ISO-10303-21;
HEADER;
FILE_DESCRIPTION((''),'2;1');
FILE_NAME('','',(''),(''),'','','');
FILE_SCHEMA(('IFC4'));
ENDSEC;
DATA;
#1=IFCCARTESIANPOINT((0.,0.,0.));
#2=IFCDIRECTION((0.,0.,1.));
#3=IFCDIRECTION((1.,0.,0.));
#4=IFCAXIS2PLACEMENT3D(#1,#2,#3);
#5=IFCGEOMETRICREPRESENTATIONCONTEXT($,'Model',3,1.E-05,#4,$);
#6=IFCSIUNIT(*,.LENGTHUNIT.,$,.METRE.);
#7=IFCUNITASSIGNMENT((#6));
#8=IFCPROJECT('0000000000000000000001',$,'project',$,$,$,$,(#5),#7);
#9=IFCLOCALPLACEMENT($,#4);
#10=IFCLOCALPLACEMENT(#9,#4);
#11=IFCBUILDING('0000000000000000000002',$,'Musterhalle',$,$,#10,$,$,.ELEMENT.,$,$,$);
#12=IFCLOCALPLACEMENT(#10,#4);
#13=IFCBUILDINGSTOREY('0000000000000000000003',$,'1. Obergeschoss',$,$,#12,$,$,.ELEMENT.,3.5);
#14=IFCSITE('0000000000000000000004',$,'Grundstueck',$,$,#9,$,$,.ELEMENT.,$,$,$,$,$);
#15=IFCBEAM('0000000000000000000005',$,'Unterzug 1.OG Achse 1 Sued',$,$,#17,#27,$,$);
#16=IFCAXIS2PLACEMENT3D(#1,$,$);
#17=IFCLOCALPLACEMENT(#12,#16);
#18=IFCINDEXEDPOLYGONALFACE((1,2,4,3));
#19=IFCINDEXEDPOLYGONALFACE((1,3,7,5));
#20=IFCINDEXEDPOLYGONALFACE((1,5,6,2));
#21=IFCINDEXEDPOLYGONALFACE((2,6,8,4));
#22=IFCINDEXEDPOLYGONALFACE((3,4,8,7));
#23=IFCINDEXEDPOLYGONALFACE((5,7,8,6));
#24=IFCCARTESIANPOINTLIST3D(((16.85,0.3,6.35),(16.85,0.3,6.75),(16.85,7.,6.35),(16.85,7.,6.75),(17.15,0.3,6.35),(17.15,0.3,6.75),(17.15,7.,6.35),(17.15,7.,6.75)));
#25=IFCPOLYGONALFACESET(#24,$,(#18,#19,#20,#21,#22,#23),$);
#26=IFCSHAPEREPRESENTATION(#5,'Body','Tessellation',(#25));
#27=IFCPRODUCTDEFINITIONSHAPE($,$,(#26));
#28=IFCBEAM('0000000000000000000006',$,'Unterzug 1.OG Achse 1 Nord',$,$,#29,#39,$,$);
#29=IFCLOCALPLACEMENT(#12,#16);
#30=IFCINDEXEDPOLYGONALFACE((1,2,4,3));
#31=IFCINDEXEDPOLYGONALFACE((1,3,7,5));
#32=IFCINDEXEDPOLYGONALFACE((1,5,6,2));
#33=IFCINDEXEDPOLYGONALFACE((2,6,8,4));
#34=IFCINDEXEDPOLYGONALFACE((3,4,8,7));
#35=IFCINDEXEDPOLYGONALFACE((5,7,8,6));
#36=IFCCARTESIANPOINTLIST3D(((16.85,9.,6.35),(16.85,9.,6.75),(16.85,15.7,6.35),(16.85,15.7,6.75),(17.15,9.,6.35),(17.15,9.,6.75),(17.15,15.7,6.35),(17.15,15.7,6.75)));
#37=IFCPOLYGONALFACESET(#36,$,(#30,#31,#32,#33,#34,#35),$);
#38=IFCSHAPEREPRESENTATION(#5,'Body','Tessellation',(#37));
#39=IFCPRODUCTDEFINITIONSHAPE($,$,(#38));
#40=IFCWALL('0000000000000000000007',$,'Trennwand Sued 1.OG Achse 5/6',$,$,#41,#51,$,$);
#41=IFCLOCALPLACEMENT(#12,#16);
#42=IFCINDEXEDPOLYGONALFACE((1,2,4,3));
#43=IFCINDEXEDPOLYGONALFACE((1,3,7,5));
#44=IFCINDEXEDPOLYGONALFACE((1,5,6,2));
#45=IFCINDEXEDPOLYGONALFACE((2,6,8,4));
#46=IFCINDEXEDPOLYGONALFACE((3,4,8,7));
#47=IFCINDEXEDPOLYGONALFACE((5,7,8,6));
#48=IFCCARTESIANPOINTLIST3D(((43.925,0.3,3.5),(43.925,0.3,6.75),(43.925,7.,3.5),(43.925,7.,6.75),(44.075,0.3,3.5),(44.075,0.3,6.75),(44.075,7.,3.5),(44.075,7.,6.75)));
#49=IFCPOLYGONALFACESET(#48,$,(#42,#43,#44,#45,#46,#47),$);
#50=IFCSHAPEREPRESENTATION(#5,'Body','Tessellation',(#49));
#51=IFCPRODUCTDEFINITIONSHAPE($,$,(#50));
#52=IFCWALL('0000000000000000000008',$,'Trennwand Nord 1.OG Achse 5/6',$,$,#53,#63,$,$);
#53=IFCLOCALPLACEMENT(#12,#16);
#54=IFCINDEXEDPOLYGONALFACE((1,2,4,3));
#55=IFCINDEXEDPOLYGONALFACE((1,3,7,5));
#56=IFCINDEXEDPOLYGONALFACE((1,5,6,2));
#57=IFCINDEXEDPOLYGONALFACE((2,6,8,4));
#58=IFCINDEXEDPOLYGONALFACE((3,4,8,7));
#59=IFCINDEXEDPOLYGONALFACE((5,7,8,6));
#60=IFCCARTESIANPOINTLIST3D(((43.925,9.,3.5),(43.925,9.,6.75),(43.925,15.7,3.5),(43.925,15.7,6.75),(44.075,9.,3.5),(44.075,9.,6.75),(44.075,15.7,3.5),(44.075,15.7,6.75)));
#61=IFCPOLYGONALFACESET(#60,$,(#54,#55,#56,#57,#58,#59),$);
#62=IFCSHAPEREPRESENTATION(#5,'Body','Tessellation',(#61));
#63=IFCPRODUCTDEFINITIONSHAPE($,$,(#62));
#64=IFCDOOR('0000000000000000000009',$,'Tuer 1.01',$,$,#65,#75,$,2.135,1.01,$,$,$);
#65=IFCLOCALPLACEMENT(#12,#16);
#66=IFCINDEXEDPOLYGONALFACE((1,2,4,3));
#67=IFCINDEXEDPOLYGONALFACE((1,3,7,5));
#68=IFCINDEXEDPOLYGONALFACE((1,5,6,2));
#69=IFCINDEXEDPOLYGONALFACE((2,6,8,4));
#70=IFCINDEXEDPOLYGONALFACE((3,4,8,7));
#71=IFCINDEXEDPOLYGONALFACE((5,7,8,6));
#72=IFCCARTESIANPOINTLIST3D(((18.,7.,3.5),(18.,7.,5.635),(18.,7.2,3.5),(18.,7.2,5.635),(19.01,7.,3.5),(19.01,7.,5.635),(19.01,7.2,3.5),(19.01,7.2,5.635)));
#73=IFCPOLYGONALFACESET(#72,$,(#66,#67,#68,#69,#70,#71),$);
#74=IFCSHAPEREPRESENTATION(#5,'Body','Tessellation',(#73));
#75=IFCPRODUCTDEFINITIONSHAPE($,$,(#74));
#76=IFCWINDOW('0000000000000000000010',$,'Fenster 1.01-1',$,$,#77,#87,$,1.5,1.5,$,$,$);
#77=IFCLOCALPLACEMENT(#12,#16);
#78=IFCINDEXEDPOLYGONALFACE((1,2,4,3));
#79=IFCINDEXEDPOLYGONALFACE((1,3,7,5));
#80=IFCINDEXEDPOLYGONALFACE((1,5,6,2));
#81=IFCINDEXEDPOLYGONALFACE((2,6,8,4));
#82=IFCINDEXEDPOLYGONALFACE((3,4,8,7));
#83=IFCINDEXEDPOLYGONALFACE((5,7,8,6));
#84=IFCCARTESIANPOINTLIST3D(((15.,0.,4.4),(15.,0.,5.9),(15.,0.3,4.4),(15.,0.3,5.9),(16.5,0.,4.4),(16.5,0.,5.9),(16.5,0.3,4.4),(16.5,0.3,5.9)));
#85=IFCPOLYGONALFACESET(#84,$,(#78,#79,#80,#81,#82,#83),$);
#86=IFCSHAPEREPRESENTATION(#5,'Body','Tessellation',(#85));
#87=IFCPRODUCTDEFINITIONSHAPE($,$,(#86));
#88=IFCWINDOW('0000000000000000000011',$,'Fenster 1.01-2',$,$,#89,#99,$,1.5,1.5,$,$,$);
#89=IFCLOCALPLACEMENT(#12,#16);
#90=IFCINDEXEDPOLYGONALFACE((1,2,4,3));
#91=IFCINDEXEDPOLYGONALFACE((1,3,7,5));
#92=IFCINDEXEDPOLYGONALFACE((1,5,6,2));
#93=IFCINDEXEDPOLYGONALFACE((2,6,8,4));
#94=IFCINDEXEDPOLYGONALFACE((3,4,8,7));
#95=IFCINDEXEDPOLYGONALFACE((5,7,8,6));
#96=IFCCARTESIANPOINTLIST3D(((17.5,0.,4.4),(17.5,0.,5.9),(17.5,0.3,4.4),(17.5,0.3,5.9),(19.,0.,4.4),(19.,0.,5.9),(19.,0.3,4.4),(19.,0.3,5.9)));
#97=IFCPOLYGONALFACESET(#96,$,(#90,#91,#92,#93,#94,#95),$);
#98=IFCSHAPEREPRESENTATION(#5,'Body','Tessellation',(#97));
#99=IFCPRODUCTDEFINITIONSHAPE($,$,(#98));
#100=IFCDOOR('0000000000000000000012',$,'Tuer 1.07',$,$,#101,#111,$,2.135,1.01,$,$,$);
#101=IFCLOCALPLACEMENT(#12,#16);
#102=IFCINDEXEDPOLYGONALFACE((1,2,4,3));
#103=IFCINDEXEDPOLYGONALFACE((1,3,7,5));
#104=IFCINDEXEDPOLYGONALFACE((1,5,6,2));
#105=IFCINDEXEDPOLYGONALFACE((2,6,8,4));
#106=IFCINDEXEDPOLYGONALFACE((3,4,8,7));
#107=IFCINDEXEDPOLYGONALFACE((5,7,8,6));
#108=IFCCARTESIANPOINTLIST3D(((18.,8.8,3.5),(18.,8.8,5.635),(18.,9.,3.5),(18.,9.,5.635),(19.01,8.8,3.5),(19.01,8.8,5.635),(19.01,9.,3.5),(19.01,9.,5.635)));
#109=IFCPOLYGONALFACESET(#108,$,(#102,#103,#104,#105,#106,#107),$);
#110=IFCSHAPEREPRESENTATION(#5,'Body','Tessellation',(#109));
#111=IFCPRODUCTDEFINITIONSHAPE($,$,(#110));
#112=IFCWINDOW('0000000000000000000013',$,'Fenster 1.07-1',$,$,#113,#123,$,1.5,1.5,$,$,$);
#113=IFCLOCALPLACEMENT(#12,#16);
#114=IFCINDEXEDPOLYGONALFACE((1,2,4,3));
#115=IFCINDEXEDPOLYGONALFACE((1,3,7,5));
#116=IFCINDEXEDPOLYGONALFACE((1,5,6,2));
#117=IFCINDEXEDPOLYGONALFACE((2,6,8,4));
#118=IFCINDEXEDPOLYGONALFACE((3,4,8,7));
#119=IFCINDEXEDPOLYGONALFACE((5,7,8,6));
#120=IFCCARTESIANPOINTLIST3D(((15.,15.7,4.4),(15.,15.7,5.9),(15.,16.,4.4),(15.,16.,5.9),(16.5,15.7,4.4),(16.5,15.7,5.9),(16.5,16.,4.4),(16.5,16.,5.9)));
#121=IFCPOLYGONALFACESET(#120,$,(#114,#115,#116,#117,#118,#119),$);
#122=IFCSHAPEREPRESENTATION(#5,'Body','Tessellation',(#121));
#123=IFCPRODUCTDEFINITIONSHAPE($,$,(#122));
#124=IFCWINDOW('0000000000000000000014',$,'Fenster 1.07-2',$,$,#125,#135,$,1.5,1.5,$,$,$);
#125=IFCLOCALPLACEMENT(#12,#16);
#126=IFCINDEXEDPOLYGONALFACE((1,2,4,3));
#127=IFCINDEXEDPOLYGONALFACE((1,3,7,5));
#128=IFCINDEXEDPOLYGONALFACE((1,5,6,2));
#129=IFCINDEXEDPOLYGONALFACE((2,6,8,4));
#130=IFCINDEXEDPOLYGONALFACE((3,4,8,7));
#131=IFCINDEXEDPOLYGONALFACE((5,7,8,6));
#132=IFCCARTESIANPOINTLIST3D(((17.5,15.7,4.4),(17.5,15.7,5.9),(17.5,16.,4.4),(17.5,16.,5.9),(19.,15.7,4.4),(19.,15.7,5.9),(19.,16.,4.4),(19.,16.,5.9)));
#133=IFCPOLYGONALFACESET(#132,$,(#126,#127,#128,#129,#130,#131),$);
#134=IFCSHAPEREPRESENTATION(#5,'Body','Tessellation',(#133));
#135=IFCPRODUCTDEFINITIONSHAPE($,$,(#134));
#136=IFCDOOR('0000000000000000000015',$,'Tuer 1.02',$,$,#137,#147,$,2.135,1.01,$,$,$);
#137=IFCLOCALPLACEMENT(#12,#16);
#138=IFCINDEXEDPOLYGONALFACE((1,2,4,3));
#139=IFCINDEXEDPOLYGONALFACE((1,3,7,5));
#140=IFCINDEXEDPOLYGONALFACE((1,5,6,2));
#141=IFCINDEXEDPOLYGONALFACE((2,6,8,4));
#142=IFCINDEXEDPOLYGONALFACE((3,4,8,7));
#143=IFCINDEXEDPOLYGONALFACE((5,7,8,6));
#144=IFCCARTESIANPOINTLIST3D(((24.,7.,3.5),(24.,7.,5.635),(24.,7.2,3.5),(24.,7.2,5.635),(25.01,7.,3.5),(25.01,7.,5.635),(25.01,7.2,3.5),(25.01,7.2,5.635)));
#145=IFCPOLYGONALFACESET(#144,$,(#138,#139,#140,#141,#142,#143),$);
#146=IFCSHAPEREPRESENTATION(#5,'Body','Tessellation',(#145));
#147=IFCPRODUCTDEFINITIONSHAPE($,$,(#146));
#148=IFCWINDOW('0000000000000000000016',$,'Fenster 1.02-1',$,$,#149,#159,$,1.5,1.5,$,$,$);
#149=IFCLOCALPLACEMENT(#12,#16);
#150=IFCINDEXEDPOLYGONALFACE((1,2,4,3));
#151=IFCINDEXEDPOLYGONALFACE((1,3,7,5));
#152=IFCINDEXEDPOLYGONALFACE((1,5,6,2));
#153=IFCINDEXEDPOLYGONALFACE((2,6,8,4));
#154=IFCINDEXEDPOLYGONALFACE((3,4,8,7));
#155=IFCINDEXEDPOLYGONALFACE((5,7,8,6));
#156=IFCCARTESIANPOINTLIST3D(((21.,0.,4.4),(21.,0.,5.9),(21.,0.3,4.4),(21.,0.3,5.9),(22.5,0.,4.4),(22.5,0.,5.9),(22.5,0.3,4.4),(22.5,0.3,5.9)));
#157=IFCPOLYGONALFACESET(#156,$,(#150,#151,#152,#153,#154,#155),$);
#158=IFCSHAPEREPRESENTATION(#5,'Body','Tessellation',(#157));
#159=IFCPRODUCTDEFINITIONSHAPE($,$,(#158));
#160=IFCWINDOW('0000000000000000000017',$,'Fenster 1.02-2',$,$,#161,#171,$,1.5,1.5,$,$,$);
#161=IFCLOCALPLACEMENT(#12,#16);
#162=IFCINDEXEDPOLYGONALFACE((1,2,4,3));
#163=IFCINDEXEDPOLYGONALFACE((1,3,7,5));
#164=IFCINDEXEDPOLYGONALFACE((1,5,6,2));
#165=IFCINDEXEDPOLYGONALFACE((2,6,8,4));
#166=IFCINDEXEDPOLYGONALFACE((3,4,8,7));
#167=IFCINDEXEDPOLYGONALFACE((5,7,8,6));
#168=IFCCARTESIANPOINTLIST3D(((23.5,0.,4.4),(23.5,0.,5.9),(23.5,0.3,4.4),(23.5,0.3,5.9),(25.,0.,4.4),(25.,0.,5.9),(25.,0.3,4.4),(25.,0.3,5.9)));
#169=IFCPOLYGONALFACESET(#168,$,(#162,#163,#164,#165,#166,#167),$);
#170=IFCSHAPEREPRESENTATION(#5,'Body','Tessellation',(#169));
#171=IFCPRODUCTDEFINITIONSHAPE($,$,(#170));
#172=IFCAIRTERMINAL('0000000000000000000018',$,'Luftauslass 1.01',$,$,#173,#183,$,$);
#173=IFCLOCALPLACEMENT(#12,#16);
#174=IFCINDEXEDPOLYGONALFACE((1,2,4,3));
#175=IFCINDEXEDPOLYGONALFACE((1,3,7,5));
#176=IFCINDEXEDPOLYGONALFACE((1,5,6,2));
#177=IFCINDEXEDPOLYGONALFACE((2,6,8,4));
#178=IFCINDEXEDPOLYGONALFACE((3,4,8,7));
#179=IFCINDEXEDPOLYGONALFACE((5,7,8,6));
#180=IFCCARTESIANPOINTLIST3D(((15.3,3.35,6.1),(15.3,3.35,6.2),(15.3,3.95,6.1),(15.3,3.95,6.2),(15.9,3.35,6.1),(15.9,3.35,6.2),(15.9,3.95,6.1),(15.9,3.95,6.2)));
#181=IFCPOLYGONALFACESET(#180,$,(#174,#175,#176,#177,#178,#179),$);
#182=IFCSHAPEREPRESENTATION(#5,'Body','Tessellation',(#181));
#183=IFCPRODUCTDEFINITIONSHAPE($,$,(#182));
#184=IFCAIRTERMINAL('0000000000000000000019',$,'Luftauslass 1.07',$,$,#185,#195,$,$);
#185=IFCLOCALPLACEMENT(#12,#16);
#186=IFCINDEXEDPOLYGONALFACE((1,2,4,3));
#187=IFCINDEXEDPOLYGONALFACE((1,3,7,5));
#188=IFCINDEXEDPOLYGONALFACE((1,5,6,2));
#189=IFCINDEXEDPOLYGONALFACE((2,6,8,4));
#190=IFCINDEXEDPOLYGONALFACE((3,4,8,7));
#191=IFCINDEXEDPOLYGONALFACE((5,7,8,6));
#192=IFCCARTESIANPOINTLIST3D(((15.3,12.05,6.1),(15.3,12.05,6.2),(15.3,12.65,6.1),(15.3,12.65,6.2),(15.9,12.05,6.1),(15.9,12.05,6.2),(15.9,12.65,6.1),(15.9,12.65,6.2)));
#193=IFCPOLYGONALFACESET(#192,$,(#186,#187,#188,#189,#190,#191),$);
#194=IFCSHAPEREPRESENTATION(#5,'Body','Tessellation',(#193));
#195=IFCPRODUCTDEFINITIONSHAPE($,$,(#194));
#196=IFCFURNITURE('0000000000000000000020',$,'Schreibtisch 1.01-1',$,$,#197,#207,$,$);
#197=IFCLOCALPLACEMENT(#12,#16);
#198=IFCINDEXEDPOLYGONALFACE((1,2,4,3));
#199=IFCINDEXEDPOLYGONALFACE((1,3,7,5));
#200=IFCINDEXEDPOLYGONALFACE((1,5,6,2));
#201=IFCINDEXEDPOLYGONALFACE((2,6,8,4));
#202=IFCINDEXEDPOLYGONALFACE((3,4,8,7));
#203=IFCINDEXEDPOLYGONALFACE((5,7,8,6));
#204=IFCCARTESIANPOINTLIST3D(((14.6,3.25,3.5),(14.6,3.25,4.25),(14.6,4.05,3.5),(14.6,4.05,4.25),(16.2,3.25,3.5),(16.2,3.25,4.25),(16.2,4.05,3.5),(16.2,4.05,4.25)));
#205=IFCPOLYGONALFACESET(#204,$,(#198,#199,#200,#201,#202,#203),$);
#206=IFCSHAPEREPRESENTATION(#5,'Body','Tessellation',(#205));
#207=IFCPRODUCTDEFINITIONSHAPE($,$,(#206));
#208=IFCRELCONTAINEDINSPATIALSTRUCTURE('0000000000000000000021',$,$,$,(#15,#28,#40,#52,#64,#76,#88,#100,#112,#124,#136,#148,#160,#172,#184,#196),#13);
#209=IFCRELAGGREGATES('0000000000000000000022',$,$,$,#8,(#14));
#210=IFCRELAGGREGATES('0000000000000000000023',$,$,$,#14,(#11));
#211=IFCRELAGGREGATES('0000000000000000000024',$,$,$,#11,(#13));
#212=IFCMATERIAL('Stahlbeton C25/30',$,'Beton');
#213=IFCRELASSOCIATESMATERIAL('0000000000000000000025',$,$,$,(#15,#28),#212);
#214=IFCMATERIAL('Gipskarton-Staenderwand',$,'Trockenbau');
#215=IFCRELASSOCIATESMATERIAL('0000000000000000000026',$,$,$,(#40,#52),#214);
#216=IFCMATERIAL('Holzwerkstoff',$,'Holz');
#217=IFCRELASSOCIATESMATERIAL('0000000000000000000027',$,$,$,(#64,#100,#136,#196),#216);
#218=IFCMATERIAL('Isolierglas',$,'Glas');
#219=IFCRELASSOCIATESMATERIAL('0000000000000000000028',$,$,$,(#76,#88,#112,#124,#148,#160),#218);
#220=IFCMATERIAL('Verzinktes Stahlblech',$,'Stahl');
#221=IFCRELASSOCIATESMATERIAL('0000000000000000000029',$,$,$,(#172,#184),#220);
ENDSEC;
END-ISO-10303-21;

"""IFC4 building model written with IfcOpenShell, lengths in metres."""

from ifc_helpers import new_model, si_unit, frame, origin_with_axes, origin_2d, place, context, project, spatial, rectangle, extrude, material, element, save


model = new_model("IFC4")

# Units and contexts
model_context = context("Model", 3, precision=1e-05, world=origin_with_axes())
ifc_project = project(units=[si_unit("LENGTHUNIT", "METRE")], contexts=[model_context])

# Site, building, storey
site_placement = place(None, origin_with_axes())
site = spatial("IfcSite", under=ifc_project, at=site_placement, Name="Grundstueck", CompositionType="ELEMENT")
building_placement = place(site_placement, origin_with_axes())
building = spatial("IfcBuilding", under=site, at=building_placement, Name="Musterhalle", CompositionType="ELEMENT")
storey_placement = place(building_placement, origin_with_axes())
storey = spatial("IfcBuildingStorey", under=building, at=storey_placement, Name="1. Obergeschoss", CompositionType="ELEMENT", Elevation=3.5)

# Beams
ifc_material_1 = material(Name="Stahlbeton C25/30", Category="Beton")
placement = place(storey_placement, origin_with_axes())
element("IfcBeam", 1, at=placement, inside=storey, material=ifc_material_1, Name="Unterzug 1.OG Achse 1 Sued", context=model_context, shape_type="SweptSolid", body=[
    extrude(rectangle(XDim=0.3, YDim=6.7, at=origin_2d()), frame((17.0, 3.65, 6.35), z_axis=(0.0, 0.0, 1.0), x_axis=(1.0, 0.0, 0.0)), (0.0, 0.0, 1.0), 0.4),
])
element("IfcBeam", 2, at=placement, inside=storey, material=ifc_material_1, Name="Unterzug 1.OG Achse 1 Nord", context=model_context, shape_type="SweptSolid", body=[
    extrude(rectangle(XDim=0.3, YDim=6.7, at=origin_2d()), frame((17.0, 12.35, 6.35), z_axis=(0.0, 0.0, 1.0), x_axis=(1.0, 0.0, 0.0)), (0.0, 0.0, 1.0), 0.4),
])

# Walls
ifc_material_2 = material(Name="Gipskarton-Staenderwand", Category="Trockenbau")
element("IfcWall", 3, at=placement, inside=storey, material=ifc_material_2, Name="Trennwand Sued 1.OG Achse 5/6", context=model_context, shape_type="SweptSolid", body=[
    extrude(rectangle(XDim=0.15, YDim=6.7, at=origin_2d()), frame((44.0, 3.65, 3.5), z_axis=(0.0, 0.0, 1.0), x_axis=(1.0, 0.0, 0.0)), (0.0, 0.0, 1.0), 3.25),
])
element("IfcWall", 4, at=placement, inside=storey, material=ifc_material_2, Name="Trennwand Nord 1.OG Achse 5/6", context=model_context, shape_type="SweptSolid", body=[
    extrude(rectangle(XDim=0.15, YDim=6.7, at=origin_2d()), frame((44.0, 12.35, 3.5), z_axis=(0.0, 0.0, 1.0), x_axis=(1.0, 0.0, 0.0)), (0.0, 0.0, 1.0), 3.25),
])

# Door
ifc_material_3 = material(Name="Holzwerkstoff", Category="Holz")
element("IfcDoor", 5, at=placement, inside=storey, material=ifc_material_3, Name="Tuer 1.01", OverallHeight=2.135, OverallWidth=1.01, context=model_context, shape_type="SweptSolid", body=[
    extrude(rectangle(XDim=1.01, YDim=0.2, at=origin_2d()), frame((18.505, 7.1, 3.5), z_axis=(0.0, 0.0, 1.0), x_axis=(1.0, 0.0, 0.0)), (0.0, 0.0, 1.0), 2.135),
])

# Windows
ifc_material_4 = material(Name="Isolierglas", Category="Glas")
element("IfcWindow", 6, at=placement, inside=storey, material=ifc_material_4, Name="Fenster 1.01-1", OverallHeight=1.5, OverallWidth=1.5, context=model_context, shape_type="SweptSolid", body=[
    extrude(rectangle(XDim=1.5, YDim=0.3, at=origin_2d()), frame((15.75, 0.15, 4.4), z_axis=(0.0, 0.0, 1.0), x_axis=(1.0, 0.0, 0.0)), (0.0, 0.0, 1.0), 1.5),
])
element("IfcWindow", 7, at=placement, inside=storey, material=ifc_material_4, Name="Fenster 1.01-2", OverallHeight=1.5, OverallWidth=1.5, context=model_context, shape_type="SweptSolid", body=[
    extrude(rectangle(XDim=1.5, YDim=0.3, at=origin_2d()), frame((18.25, 0.15, 4.4), z_axis=(0.0, 0.0, 1.0), x_axis=(1.0, 0.0, 0.0)), (0.0, 0.0, 1.0), 1.5),
])

# Door
element("IfcDoor", 8, at=placement, inside=storey, material=ifc_material_3, Name="Tuer 1.07", OverallHeight=2.135, OverallWidth=1.01, context=model_context, shape_type="SweptSolid", body=[
    extrude(rectangle(XDim=1.01, YDim=0.2, at=origin_2d()), frame((18.505, 8.9, 3.5), z_axis=(0.0, 0.0, 1.0), x_axis=(1.0, 0.0, 0.0)), (0.0, 0.0, 1.0), 2.135),
])

# Windows
element("IfcWindow", 9, at=placement, inside=storey, material=ifc_material_4, Name="Fenster 1.07-1", OverallHeight=1.5, OverallWidth=1.5, context=model_context, shape_type="SweptSolid", body=[
    extrude(rectangle(XDim=1.5, YDim=0.3, at=origin_2d()), frame((15.75, 15.85, 4.4), z_axis=(0.0, 0.0, 1.0), x_axis=(1.0, 0.0, 0.0)), (0.0, 0.0, 1.0), 1.5),
])
element("IfcWindow", 10, at=placement, inside=storey, material=ifc_material_4, Name="Fenster 1.07-2", OverallHeight=1.5, OverallWidth=1.5, context=model_context, shape_type="SweptSolid", body=[
    extrude(rectangle(XDim=1.5, YDim=0.3, at=origin_2d()), frame((18.25, 15.85, 4.4), z_axis=(0.0, 0.0, 1.0), x_axis=(1.0, 0.0, 0.0)), (0.0, 0.0, 1.0), 1.5),
])

# Door
element("IfcDoor", 11, at=placement, inside=storey, material=ifc_material_3, Name="Tuer 1.02", OverallHeight=2.135, OverallWidth=1.01, context=model_context, shape_type="SweptSolid", body=[
    extrude(rectangle(XDim=1.01, YDim=0.2, at=origin_2d()), frame((24.505, 7.1, 3.5), z_axis=(0.0, 0.0, 1.0), x_axis=(1.0, 0.0, 0.0)), (0.0, 0.0, 1.0), 2.135),
])

# Windows
element("IfcWindow", 12, at=placement, inside=storey, material=ifc_material_4, Name="Fenster 1.02-1", OverallHeight=1.5, OverallWidth=1.5, context=model_context, shape_type="SweptSolid", body=[
    extrude(rectangle(XDim=1.5, YDim=0.3, at=origin_2d()), frame((21.75, 0.15, 4.4), z_axis=(0.0, 0.0, 1.0), x_axis=(1.0, 0.0, 0.0)), (0.0, 0.0, 1.0), 1.5),
])
element("IfcWindow", 13, at=placement, inside=storey, material=ifc_material_4, Name="Fenster 1.02-2", OverallHeight=1.5, OverallWidth=1.5, context=model_context, shape_type="SweptSolid", body=[
    extrude(rectangle(XDim=1.5, YDim=0.3, at=origin_2d()), frame((24.25, 0.15, 4.4), z_axis=(0.0, 0.0, 1.0), x_axis=(1.0, 0.0, 0.0)), (0.0, 0.0, 1.0), 1.5),
])

# Air terminals
ifc_material_5 = material(Name="Verzinktes Stahlblech", Category="Stahl")
element("IfcAirTerminal", 14, at=placement, inside=storey, material=ifc_material_5, Name="Luftauslass 1.01", context=model_context, shape_type="SweptSolid", body=[
    extrude(rectangle(XDim=0.6, YDim=0.6, at=origin_2d()), frame((15.6, 3.65, 6.1), z_axis=(0.0, 0.0, 1.0), x_axis=(1.0, 0.0, 0.0)), (0.0, 0.0, 1.0), 0.1),
])
element("IfcAirTerminal", 15, at=placement, inside=storey, material=ifc_material_5, Name="Luftauslass 1.07", context=model_context, shape_type="SweptSolid", body=[
    extrude(rectangle(XDim=0.6, YDim=0.6, at=origin_2d()), frame((15.6, 12.35, 6.1), z_axis=(0.0, 0.0, 1.0), x_axis=(1.0, 0.0, 0.0)), (0.0, 0.0, 1.0), 0.1),
])

# Furniture
element("IfcFurniture", 16, at=placement, inside=storey, material=ifc_material_3, Name="Schreibtisch 1.01-1", context=model_context, shape_type="SweptSolid", body=[
    extrude(rectangle(XDim=1.6, YDim=0.8, at=origin_2d()), frame((15.4, 3.65, 3.5), z_axis=(0.0, 0.0, 1.0), x_axis=(1.0, 0.0, 0.0)), (0.0, 0.0, 1.0), 0.75),
])

save(model, "model.ifc")
